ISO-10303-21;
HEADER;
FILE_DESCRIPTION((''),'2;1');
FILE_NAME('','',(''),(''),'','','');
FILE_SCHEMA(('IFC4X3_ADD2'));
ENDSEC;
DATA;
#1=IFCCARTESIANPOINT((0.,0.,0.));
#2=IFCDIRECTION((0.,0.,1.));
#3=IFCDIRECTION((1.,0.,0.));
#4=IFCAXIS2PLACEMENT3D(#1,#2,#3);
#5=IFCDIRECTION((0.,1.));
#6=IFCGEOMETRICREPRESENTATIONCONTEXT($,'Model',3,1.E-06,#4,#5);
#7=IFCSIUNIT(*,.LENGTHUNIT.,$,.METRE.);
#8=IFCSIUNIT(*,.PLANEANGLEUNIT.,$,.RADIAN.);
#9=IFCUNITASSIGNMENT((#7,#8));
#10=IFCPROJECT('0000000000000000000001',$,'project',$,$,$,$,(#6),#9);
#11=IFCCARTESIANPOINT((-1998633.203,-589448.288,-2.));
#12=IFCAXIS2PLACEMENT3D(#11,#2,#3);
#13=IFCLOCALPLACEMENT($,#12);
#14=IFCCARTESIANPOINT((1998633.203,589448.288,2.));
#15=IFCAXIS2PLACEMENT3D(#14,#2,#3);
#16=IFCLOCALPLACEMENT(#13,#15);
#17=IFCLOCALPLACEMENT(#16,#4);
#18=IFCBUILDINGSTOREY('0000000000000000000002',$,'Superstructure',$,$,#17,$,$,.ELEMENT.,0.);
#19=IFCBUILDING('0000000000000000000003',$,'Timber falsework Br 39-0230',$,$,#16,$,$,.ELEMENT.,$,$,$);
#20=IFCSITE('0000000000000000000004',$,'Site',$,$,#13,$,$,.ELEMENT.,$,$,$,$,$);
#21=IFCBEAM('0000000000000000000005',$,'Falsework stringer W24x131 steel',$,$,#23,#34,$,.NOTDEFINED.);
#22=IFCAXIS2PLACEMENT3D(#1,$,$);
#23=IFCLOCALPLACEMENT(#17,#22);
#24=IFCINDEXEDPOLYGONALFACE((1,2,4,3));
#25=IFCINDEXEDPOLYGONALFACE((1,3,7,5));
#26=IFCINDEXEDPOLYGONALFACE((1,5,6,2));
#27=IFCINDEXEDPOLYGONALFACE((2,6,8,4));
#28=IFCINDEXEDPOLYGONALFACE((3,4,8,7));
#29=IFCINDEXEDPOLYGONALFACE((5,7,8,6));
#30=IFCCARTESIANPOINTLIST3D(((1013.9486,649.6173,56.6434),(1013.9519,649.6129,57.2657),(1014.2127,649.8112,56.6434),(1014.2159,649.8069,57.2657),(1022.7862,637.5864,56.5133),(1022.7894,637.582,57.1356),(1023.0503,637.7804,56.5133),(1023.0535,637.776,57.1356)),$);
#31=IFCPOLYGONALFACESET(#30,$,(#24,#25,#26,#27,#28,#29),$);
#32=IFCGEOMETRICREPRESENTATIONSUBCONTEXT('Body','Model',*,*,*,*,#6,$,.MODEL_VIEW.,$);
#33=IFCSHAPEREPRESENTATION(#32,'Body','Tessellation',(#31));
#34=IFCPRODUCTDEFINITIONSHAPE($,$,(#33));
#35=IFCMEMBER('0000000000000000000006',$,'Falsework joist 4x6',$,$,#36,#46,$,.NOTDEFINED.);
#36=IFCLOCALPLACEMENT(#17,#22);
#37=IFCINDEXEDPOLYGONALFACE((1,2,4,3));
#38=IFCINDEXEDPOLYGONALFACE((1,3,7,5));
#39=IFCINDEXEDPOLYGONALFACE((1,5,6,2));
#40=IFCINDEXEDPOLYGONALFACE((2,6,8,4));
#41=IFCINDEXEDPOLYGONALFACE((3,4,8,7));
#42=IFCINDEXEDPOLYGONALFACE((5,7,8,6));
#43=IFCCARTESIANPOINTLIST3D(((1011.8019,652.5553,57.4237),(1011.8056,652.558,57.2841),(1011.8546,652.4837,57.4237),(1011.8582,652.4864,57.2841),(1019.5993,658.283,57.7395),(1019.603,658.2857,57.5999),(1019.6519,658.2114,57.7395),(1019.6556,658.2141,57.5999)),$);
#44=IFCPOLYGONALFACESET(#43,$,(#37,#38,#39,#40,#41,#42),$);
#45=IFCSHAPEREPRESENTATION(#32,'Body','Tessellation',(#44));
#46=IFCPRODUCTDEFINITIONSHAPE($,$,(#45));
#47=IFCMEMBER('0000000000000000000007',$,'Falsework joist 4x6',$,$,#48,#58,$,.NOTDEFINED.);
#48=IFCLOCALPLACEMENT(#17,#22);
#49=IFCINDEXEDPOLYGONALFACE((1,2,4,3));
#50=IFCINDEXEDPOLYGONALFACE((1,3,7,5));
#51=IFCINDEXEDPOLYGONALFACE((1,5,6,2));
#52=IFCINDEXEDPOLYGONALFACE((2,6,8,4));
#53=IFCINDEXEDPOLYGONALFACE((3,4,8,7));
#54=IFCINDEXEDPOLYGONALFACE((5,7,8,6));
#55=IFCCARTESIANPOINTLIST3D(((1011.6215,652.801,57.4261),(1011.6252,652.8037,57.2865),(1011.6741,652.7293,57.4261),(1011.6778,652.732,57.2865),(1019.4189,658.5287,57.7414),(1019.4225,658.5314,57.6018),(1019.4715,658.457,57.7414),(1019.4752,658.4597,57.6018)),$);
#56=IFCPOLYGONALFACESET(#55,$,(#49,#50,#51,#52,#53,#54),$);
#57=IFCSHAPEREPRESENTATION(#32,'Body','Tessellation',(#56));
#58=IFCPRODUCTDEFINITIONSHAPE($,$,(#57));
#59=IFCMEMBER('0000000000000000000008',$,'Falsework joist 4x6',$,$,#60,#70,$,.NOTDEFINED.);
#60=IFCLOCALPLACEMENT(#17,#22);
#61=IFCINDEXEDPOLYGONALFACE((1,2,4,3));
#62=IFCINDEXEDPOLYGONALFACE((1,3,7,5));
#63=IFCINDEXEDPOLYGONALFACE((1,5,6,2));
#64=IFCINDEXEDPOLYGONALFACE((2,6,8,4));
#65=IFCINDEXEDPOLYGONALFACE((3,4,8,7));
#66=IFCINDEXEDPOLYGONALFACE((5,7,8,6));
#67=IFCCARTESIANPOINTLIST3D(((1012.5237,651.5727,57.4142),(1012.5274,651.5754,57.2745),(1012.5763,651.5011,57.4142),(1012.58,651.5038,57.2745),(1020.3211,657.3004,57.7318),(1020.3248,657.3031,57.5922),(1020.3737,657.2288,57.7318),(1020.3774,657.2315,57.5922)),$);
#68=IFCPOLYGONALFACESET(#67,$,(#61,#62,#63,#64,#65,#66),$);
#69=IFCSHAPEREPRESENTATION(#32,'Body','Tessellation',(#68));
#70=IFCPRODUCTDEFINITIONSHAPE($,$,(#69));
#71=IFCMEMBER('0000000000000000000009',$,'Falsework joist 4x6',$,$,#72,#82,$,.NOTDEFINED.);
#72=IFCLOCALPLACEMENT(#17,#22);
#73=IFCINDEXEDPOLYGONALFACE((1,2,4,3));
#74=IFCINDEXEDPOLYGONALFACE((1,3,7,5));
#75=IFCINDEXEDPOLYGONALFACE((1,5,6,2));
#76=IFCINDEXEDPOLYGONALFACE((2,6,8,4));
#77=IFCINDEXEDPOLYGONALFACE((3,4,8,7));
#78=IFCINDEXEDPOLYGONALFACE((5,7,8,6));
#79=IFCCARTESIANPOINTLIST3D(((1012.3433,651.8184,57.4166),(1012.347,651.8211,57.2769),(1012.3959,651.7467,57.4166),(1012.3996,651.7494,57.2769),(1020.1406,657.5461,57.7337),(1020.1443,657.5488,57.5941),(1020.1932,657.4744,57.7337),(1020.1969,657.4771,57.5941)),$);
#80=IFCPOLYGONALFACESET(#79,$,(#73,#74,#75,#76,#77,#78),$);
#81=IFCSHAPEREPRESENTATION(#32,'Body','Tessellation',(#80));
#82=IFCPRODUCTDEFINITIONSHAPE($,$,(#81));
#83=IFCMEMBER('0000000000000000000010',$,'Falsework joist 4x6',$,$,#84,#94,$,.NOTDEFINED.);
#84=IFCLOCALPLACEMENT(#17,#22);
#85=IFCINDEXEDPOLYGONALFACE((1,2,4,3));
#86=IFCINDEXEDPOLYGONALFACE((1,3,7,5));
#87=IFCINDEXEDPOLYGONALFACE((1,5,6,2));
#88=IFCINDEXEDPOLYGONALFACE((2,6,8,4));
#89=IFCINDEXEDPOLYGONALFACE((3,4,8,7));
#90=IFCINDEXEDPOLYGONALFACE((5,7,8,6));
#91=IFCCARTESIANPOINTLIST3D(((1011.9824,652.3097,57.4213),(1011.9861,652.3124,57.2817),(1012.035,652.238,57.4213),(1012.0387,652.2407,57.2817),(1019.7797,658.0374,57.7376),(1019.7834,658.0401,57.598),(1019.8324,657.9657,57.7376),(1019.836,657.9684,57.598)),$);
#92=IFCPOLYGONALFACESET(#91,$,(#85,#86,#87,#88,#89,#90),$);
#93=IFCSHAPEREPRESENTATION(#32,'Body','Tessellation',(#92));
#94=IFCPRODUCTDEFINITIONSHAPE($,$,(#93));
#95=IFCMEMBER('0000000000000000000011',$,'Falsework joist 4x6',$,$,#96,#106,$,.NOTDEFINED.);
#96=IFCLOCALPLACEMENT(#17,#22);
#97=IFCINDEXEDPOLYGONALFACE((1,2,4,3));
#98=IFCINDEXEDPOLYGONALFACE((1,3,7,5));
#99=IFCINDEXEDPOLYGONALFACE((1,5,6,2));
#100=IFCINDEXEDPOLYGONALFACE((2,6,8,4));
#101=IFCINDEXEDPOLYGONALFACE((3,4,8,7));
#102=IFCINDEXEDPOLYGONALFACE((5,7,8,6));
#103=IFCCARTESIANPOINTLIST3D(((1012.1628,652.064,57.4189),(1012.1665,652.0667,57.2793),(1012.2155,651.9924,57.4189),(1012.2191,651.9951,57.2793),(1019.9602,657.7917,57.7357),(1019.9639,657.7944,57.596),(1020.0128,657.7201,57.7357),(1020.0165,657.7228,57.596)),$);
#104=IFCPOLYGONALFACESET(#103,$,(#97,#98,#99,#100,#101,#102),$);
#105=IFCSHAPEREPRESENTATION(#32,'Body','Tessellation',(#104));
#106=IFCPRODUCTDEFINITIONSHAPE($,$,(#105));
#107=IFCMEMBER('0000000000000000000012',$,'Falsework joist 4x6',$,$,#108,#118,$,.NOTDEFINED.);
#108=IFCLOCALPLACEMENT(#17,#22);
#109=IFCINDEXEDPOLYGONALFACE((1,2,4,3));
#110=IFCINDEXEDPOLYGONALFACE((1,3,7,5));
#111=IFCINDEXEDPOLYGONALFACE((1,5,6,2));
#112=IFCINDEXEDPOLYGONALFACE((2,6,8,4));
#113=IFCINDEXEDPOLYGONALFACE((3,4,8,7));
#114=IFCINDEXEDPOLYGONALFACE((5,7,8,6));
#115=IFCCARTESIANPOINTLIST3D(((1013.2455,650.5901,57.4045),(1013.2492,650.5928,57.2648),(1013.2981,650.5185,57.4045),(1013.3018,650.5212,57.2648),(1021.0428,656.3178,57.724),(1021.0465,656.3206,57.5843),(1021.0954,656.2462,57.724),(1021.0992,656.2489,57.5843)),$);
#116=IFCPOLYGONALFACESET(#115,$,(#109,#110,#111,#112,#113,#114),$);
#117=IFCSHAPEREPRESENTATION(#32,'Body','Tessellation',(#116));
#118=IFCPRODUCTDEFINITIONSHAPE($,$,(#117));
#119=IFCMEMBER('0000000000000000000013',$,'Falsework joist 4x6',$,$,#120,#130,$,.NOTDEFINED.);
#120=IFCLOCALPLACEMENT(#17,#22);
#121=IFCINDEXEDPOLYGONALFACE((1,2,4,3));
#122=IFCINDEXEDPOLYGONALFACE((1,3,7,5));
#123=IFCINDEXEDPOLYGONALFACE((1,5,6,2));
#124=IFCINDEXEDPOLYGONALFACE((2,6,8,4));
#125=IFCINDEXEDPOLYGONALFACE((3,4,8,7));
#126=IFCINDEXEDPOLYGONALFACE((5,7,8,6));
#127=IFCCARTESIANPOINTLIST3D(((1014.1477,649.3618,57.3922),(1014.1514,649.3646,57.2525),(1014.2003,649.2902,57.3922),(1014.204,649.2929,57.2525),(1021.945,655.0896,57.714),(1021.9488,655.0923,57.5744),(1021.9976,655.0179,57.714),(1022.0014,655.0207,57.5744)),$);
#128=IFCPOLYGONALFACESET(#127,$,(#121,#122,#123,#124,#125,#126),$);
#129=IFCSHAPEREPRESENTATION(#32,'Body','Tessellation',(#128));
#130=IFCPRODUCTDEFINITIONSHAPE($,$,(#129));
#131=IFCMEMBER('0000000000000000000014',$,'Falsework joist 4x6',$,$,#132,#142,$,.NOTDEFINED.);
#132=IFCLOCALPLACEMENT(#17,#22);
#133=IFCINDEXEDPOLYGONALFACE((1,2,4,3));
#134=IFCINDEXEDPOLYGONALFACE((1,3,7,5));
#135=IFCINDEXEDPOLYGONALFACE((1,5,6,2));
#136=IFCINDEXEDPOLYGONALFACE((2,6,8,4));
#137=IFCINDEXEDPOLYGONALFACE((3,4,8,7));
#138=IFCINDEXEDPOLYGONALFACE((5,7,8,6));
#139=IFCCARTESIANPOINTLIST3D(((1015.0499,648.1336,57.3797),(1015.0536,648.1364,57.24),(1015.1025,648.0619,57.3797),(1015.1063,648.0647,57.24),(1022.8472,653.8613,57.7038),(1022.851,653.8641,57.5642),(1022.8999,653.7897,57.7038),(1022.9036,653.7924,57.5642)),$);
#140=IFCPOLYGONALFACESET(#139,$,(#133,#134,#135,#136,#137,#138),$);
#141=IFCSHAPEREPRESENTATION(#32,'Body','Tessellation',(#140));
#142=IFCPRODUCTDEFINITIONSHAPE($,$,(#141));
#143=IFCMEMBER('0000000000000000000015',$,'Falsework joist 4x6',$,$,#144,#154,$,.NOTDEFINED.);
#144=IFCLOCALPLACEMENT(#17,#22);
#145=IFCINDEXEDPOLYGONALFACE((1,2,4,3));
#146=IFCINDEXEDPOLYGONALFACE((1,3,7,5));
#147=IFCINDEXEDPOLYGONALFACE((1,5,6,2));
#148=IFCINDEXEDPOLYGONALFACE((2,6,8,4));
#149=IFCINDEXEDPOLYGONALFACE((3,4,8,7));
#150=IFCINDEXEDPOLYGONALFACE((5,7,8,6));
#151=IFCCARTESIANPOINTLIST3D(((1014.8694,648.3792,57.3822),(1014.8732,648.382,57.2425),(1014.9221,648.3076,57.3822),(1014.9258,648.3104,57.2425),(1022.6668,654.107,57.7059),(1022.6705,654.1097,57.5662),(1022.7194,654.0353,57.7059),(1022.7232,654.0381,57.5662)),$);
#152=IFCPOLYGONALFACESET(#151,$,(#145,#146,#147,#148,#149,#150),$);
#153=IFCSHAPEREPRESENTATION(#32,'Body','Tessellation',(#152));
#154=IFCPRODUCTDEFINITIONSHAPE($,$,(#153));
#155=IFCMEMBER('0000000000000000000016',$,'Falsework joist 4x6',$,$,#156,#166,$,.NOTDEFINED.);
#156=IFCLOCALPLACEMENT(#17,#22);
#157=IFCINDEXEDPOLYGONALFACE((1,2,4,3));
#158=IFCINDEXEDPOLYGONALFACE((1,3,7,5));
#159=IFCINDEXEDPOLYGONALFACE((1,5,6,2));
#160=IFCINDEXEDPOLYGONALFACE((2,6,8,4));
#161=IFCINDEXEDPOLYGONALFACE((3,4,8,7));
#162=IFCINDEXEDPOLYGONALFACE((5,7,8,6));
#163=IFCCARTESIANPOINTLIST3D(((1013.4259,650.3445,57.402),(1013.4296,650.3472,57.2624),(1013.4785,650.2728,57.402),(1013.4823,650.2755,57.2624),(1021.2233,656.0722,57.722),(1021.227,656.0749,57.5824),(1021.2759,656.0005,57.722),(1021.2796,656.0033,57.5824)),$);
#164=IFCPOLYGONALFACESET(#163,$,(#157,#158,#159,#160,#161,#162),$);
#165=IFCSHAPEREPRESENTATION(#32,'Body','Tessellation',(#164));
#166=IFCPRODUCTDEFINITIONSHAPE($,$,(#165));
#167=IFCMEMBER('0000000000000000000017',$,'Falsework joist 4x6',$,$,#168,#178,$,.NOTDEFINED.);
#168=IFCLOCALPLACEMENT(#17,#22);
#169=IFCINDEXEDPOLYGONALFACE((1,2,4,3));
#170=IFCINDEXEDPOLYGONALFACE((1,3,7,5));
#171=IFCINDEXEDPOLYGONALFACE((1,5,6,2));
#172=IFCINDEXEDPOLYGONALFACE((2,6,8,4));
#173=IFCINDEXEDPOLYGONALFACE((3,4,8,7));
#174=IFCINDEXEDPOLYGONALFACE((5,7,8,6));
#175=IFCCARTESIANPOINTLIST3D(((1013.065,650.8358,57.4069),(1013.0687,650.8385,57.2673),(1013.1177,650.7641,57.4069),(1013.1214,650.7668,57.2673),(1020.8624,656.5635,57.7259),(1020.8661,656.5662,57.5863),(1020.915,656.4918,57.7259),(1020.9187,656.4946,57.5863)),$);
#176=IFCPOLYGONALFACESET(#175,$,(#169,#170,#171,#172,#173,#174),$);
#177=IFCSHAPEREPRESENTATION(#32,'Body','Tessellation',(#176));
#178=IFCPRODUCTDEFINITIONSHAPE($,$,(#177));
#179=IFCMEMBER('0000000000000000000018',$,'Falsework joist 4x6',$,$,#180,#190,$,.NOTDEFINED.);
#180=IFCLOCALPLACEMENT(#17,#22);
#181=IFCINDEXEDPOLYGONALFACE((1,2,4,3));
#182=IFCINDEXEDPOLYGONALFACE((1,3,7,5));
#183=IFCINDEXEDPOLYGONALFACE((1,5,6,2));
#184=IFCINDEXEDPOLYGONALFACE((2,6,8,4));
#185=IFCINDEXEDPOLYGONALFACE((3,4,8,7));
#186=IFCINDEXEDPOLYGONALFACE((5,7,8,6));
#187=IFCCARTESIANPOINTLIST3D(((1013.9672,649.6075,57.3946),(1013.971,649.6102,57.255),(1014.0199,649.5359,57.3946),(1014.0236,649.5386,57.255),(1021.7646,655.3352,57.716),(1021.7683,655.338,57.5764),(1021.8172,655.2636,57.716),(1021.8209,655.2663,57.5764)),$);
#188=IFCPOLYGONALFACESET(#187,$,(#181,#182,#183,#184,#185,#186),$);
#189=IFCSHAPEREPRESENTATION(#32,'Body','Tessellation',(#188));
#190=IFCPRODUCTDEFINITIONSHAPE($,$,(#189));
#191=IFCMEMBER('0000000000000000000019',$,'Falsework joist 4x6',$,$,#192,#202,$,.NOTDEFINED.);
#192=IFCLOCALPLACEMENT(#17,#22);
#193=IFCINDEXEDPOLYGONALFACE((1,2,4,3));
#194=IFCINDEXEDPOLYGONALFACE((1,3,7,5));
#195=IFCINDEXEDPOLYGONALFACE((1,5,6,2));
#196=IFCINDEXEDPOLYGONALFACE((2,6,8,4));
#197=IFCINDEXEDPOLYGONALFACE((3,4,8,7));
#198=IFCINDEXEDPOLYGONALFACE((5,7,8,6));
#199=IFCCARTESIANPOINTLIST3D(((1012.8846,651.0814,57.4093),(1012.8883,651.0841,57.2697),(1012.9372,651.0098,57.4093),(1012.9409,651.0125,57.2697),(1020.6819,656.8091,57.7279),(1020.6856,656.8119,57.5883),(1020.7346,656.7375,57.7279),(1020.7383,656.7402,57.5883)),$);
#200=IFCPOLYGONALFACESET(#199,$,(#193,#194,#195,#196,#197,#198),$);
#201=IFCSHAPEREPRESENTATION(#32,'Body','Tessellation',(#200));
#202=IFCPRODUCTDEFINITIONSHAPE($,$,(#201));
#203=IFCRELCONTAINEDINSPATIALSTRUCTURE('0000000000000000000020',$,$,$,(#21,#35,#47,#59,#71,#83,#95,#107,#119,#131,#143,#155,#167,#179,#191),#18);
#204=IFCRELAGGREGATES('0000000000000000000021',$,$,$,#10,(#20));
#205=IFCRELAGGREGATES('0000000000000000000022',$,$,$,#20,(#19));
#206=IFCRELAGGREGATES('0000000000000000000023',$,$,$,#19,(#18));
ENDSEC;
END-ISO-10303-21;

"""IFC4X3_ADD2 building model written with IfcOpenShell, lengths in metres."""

from ifc_helpers import new_model, si_unit, direction, frame, frame_2d, origin, origin_with_axes, place, context, subcontext, project, spatial, rectangle, extrude, element, save


model = new_model("IFC4X3_ADD2")

# Units and contexts
model_context = context("Model", 3, precision=1e-06, world=origin_with_axes(), true_north=direction((0.0, 1.0)))
body_context = subcontext(model_context, "Body", "Model", "MODEL_VIEW")
ifc_project = project(units=[si_unit("LENGTHUNIT", "METRE"), si_unit("PLANEANGLEUNIT", "RADIAN")], contexts=[model_context])

# Site, building, storey
site_placement = place(None, frame((-1998633.203, -589448.288, -2.0), z_axis=(0.0, 0.0, 1.0), x_axis=(1.0, 0.0, 0.0)))
site = spatial("IfcSite", under=ifc_project, at=site_placement, Name="Site", CompositionType="ELEMENT")
building_placement = place(site_placement, frame((1998633.203, 589448.288, 2.0), z_axis=(0.0, 0.0, 1.0), x_axis=(1.0, 0.0, 0.0)))
building = spatial("IfcBuilding", under=site, at=building_placement, Name="Timber falsework Br 39-0230", CompositionType="ELEMENT")
storey_placement = place(building_placement, origin_with_axes())
storey = spatial("IfcBuildingStorey", under=building, at=storey_placement, Name="Superstructure", CompositionType="ELEMENT", Elevation=0.0)

# Beam
beam_placement = place(storey_placement, frame((1014.0807, 649.7143, 56.6434), z_axis=(0.591991, -0.805898, -0.008714), x_axis=(0.805928, 0.592013, 0.0)))
element("IfcBeam", 1, at=beam_placement, inside=storey, Name="Falsework stringer W24x131 steel", PredefinedType="NOTDEFINED", context=body_context, shape_type="SweptSolid", body=[
    extrude(rectangle(XDim=0.3277, YDim=0.6223, at=frame_2d((0.0, 0.3111))), origin(), (0.0, 0.0, 1.0), 14.9285),
])

# Members
member_1_placement = place(storey_placement, frame((1011.8319, 652.5222, 57.2841), z_axis=(0.805499, 0.591698, 0.032622), x_axis=(-0.592013, 0.805928, 0.0)))
element("IfcMember", 2, at=member_1_placement, inside=storey, Name="Falsework joist 4x6", PredefinedType="NOTDEFINED", context=body_context, shape_type="SweptSolid", body=[
    extrude(rectangle(XDim=0.0889, YDim=0.1397, at=frame_2d((0.0, 0.0698))), origin(), (0.0, 0.0, 1.0), 9.6802),
])
member_2_placement = place(storey_placement, frame((1011.6515, 652.7678, 57.2865), z_axis=(0.805501, 0.591699, 0.032574), x_axis=(-0.592013, 0.805928, 0.0)))
element("IfcMember", 3, at=member_2_placement, inside=storey, Name="Falsework joist 4x6", PredefinedType="NOTDEFINED", context=body_context, shape_type="SweptSolid", body=[
    extrude(rectangle(XDim=0.0889, YDim=0.1397, at=frame_2d((0.0, 0.0698))), origin(), (0.0, 0.0, 1.0), 9.6801),
])
member_3_placement = place(storey_placement, frame((1012.5537, 651.5396, 57.2745), z_axis=(0.805494, 0.591694, 0.032814), x_axis=(-0.592013, 0.805928, 0.0)))
element("IfcMember", 4, at=member_3_placement, inside=storey, Name="Falsework joist 4x6", PredefinedType="NOTDEFINED", context=body_context, shape_type="SweptSolid", body=[
    extrude(rectangle(XDim=0.0889, YDim=0.1397, at=frame_2d((0.0, 0.0698))), origin(), (0.0, 0.0, 1.0), 9.6802),
])
member_4_placement = place(storey_placement, frame((1012.3733, 651.7852, 57.2769), z_axis=(0.805496, 0.591695, 0.032766), x_axis=(-0.592013, 0.805928, 0.0)))
element("IfcMember", 5, at=member_4_placement, inside=storey, Name="Falsework joist 4x6", PredefinedType="NOTDEFINED", context=body_context, shape_type="SweptSolid", body=[
    extrude(rectangle(XDim=0.0889, YDim=0.1397, at=frame_2d((0.0, 0.0698))), origin(), (0.0, 0.0, 1.0), 9.6802),
])
member_5_placement = place(storey_placement, frame((1012.0124, 652.2765, 57.2817), z_axis=(0.805498, 0.591697, 0.03267), x_axis=(-0.592013, 0.805928, 0.0)))
element("IfcMember", 6, at=member_5_placement, inside=storey, Name="Falsework joist 4x6", PredefinedType="NOTDEFINED", context=body_context, shape_type="SweptSolid", body=[
    extrude(rectangle(XDim=0.0889, YDim=0.1397, at=frame_2d((0.0, 0.0698))), origin(), (0.0, 0.0, 1.0), 9.6802),
])
member_6_placement = place(storey_placement, frame((1012.1928, 652.0309, 57.2793), z_axis=(0.805497, 0.591696, 0.032718), x_axis=(-0.592013, 0.805928, 0.0)))
element("IfcMember", 7, at=member_6_placement, inside=storey, Name="Falsework joist 4x6", PredefinedType="NOTDEFINED", context=body_context, shape_type="SweptSolid", body=[
    extrude(rectangle(XDim=0.0889, YDim=0.1397, at=frame_2d((0.0, 0.0698))), origin(), (0.0, 0.0, 1.0), 9.6802),
])
member_7_placement = place(storey_placement, frame((1013.2755, 650.557, 57.2648), z_axis=(0.805489, 0.591691, 0.033007), x_axis=(-0.592013, 0.805928, 0.0)))
element("IfcMember", 8, at=member_7_placement, inside=storey, Name="Falsework joist 4x6", PredefinedType="NOTDEFINED", context=body_context, shape_type="SweptSolid", body=[
    extrude(rectangle(XDim=0.0889, YDim=0.1397, at=frame_2d((0.0, 0.0698))), origin(), (0.0, 0.0, 1.0), 9.6803),
])
member_8_placement = place(storey_placement, frame((1014.1777, 649.3288, 57.2525), z_axis=(0.805483, 0.591686, 0.033247), x_axis=(-0.592013, 0.805928, 0.0)))
element("IfcMember", 9, at=member_8_placement, inside=storey, Name="Falsework joist 4x6", PredefinedType="NOTDEFINED", context=body_context, shape_type="SweptSolid", body=[
    extrude(rectangle(XDim=0.0889, YDim=0.1397, at=frame_2d((0.0, 0.0698))), origin(), (0.0, 0.0, 1.0), 9.6804),
])
member_9_placement = place(storey_placement, frame((1015.0799, 648.1005, 57.24), z_axis=(0.805476, 0.591681, 0.033487), x_axis=(-0.592013, 0.805928, 0.0)))
element("IfcMember", 10, at=member_9_placement, inside=storey, Name="Falsework joist 4x6", PredefinedType="NOTDEFINED", context=body_context, shape_type="SweptSolid", body=[
    extrude(rectangle(XDim=0.0889, YDim=0.1397, at=frame_2d((0.0, 0.0698))), origin(), (0.0, 0.0, 1.0), 9.6804),
])
member_10_placement = place(storey_placement, frame((1014.8995, 648.3462, 57.2425), z_axis=(0.805478, 0.591682, 0.033439), x_axis=(-0.592013, 0.805928, 0.0)))
element("IfcMember", 11, at=member_10_placement, inside=storey, Name="Falsework joist 4x6", PredefinedType="NOTDEFINED", context=body_context, shape_type="SweptSolid", body=[
    extrude(rectangle(XDim=0.0889, YDim=0.1397, at=frame_2d((0.0, 0.0698))), origin(), (0.0, 0.0, 1.0), 9.6804),
])
member_11_placement = place(storey_placement, frame((1013.4559, 650.3114, 57.2624), z_axis=(0.805488, 0.59169, 0.033055), x_axis=(-0.592013, 0.805928, 0.0)))
element("IfcMember", 12, at=member_11_placement, inside=storey, Name="Falsework joist 4x6", PredefinedType="NOTDEFINED", context=body_context, shape_type="SweptSolid", body=[
    extrude(rectangle(XDim=0.0889, YDim=0.1397, at=frame_2d((0.0, 0.0698))), origin(), (0.0, 0.0, 1.0), 9.6803),
])
member_12_placement = place(storey_placement, frame((1013.095, 650.8027, 57.2673), z_axis=(0.80549, 0.591692, 0.032959), x_axis=(-0.592013, 0.805928, 0.0)))
element("IfcMember", 13, at=member_12_placement, inside=storey, Name="Falsework joist 4x6", PredefinedType="NOTDEFINED", context=body_context, shape_type="SweptSolid", body=[
    extrude(rectangle(XDim=0.0889, YDim=0.1397, at=frame_2d((0.0, 0.0698))), origin(), (0.0, 0.0, 1.0), 9.6803),
])
member_13_placement = place(storey_placement, frame((1013.9973, 649.5744, 57.255), z_axis=(0.805484, 0.591687, 0.033199), x_axis=(-0.592013, 0.805928, 0.0)))
element("IfcMember", 14, at=member_13_placement, inside=storey, Name="Falsework joist 4x6", PredefinedType="NOTDEFINED", context=body_context, shape_type="SweptSolid", body=[
    extrude(rectangle(XDim=0.0889, YDim=0.1397, at=frame_2d((0.0, 0.0698))), origin(), (0.0, 0.0, 1.0), 9.6803),
])
member_14_placement = place(storey_placement, frame((1012.9146, 651.0483, 57.2697), z_axis=(0.805492, 0.591692, 0.03291), x_axis=(-0.592013, 0.805928, 0.0)))
element("IfcMember", 15, at=member_14_placement, inside=storey, Name="Falsework joist 4x6", PredefinedType="NOTDEFINED", context=body_context, shape_type="SweptSolid", body=[
    extrude(rectangle(XDim=0.0889, YDim=0.1397, at=frame_2d((0.0, 0.0698))), origin(), (0.0, 0.0, 1.0), 9.6802),
])

save(model, "model.ifc")
